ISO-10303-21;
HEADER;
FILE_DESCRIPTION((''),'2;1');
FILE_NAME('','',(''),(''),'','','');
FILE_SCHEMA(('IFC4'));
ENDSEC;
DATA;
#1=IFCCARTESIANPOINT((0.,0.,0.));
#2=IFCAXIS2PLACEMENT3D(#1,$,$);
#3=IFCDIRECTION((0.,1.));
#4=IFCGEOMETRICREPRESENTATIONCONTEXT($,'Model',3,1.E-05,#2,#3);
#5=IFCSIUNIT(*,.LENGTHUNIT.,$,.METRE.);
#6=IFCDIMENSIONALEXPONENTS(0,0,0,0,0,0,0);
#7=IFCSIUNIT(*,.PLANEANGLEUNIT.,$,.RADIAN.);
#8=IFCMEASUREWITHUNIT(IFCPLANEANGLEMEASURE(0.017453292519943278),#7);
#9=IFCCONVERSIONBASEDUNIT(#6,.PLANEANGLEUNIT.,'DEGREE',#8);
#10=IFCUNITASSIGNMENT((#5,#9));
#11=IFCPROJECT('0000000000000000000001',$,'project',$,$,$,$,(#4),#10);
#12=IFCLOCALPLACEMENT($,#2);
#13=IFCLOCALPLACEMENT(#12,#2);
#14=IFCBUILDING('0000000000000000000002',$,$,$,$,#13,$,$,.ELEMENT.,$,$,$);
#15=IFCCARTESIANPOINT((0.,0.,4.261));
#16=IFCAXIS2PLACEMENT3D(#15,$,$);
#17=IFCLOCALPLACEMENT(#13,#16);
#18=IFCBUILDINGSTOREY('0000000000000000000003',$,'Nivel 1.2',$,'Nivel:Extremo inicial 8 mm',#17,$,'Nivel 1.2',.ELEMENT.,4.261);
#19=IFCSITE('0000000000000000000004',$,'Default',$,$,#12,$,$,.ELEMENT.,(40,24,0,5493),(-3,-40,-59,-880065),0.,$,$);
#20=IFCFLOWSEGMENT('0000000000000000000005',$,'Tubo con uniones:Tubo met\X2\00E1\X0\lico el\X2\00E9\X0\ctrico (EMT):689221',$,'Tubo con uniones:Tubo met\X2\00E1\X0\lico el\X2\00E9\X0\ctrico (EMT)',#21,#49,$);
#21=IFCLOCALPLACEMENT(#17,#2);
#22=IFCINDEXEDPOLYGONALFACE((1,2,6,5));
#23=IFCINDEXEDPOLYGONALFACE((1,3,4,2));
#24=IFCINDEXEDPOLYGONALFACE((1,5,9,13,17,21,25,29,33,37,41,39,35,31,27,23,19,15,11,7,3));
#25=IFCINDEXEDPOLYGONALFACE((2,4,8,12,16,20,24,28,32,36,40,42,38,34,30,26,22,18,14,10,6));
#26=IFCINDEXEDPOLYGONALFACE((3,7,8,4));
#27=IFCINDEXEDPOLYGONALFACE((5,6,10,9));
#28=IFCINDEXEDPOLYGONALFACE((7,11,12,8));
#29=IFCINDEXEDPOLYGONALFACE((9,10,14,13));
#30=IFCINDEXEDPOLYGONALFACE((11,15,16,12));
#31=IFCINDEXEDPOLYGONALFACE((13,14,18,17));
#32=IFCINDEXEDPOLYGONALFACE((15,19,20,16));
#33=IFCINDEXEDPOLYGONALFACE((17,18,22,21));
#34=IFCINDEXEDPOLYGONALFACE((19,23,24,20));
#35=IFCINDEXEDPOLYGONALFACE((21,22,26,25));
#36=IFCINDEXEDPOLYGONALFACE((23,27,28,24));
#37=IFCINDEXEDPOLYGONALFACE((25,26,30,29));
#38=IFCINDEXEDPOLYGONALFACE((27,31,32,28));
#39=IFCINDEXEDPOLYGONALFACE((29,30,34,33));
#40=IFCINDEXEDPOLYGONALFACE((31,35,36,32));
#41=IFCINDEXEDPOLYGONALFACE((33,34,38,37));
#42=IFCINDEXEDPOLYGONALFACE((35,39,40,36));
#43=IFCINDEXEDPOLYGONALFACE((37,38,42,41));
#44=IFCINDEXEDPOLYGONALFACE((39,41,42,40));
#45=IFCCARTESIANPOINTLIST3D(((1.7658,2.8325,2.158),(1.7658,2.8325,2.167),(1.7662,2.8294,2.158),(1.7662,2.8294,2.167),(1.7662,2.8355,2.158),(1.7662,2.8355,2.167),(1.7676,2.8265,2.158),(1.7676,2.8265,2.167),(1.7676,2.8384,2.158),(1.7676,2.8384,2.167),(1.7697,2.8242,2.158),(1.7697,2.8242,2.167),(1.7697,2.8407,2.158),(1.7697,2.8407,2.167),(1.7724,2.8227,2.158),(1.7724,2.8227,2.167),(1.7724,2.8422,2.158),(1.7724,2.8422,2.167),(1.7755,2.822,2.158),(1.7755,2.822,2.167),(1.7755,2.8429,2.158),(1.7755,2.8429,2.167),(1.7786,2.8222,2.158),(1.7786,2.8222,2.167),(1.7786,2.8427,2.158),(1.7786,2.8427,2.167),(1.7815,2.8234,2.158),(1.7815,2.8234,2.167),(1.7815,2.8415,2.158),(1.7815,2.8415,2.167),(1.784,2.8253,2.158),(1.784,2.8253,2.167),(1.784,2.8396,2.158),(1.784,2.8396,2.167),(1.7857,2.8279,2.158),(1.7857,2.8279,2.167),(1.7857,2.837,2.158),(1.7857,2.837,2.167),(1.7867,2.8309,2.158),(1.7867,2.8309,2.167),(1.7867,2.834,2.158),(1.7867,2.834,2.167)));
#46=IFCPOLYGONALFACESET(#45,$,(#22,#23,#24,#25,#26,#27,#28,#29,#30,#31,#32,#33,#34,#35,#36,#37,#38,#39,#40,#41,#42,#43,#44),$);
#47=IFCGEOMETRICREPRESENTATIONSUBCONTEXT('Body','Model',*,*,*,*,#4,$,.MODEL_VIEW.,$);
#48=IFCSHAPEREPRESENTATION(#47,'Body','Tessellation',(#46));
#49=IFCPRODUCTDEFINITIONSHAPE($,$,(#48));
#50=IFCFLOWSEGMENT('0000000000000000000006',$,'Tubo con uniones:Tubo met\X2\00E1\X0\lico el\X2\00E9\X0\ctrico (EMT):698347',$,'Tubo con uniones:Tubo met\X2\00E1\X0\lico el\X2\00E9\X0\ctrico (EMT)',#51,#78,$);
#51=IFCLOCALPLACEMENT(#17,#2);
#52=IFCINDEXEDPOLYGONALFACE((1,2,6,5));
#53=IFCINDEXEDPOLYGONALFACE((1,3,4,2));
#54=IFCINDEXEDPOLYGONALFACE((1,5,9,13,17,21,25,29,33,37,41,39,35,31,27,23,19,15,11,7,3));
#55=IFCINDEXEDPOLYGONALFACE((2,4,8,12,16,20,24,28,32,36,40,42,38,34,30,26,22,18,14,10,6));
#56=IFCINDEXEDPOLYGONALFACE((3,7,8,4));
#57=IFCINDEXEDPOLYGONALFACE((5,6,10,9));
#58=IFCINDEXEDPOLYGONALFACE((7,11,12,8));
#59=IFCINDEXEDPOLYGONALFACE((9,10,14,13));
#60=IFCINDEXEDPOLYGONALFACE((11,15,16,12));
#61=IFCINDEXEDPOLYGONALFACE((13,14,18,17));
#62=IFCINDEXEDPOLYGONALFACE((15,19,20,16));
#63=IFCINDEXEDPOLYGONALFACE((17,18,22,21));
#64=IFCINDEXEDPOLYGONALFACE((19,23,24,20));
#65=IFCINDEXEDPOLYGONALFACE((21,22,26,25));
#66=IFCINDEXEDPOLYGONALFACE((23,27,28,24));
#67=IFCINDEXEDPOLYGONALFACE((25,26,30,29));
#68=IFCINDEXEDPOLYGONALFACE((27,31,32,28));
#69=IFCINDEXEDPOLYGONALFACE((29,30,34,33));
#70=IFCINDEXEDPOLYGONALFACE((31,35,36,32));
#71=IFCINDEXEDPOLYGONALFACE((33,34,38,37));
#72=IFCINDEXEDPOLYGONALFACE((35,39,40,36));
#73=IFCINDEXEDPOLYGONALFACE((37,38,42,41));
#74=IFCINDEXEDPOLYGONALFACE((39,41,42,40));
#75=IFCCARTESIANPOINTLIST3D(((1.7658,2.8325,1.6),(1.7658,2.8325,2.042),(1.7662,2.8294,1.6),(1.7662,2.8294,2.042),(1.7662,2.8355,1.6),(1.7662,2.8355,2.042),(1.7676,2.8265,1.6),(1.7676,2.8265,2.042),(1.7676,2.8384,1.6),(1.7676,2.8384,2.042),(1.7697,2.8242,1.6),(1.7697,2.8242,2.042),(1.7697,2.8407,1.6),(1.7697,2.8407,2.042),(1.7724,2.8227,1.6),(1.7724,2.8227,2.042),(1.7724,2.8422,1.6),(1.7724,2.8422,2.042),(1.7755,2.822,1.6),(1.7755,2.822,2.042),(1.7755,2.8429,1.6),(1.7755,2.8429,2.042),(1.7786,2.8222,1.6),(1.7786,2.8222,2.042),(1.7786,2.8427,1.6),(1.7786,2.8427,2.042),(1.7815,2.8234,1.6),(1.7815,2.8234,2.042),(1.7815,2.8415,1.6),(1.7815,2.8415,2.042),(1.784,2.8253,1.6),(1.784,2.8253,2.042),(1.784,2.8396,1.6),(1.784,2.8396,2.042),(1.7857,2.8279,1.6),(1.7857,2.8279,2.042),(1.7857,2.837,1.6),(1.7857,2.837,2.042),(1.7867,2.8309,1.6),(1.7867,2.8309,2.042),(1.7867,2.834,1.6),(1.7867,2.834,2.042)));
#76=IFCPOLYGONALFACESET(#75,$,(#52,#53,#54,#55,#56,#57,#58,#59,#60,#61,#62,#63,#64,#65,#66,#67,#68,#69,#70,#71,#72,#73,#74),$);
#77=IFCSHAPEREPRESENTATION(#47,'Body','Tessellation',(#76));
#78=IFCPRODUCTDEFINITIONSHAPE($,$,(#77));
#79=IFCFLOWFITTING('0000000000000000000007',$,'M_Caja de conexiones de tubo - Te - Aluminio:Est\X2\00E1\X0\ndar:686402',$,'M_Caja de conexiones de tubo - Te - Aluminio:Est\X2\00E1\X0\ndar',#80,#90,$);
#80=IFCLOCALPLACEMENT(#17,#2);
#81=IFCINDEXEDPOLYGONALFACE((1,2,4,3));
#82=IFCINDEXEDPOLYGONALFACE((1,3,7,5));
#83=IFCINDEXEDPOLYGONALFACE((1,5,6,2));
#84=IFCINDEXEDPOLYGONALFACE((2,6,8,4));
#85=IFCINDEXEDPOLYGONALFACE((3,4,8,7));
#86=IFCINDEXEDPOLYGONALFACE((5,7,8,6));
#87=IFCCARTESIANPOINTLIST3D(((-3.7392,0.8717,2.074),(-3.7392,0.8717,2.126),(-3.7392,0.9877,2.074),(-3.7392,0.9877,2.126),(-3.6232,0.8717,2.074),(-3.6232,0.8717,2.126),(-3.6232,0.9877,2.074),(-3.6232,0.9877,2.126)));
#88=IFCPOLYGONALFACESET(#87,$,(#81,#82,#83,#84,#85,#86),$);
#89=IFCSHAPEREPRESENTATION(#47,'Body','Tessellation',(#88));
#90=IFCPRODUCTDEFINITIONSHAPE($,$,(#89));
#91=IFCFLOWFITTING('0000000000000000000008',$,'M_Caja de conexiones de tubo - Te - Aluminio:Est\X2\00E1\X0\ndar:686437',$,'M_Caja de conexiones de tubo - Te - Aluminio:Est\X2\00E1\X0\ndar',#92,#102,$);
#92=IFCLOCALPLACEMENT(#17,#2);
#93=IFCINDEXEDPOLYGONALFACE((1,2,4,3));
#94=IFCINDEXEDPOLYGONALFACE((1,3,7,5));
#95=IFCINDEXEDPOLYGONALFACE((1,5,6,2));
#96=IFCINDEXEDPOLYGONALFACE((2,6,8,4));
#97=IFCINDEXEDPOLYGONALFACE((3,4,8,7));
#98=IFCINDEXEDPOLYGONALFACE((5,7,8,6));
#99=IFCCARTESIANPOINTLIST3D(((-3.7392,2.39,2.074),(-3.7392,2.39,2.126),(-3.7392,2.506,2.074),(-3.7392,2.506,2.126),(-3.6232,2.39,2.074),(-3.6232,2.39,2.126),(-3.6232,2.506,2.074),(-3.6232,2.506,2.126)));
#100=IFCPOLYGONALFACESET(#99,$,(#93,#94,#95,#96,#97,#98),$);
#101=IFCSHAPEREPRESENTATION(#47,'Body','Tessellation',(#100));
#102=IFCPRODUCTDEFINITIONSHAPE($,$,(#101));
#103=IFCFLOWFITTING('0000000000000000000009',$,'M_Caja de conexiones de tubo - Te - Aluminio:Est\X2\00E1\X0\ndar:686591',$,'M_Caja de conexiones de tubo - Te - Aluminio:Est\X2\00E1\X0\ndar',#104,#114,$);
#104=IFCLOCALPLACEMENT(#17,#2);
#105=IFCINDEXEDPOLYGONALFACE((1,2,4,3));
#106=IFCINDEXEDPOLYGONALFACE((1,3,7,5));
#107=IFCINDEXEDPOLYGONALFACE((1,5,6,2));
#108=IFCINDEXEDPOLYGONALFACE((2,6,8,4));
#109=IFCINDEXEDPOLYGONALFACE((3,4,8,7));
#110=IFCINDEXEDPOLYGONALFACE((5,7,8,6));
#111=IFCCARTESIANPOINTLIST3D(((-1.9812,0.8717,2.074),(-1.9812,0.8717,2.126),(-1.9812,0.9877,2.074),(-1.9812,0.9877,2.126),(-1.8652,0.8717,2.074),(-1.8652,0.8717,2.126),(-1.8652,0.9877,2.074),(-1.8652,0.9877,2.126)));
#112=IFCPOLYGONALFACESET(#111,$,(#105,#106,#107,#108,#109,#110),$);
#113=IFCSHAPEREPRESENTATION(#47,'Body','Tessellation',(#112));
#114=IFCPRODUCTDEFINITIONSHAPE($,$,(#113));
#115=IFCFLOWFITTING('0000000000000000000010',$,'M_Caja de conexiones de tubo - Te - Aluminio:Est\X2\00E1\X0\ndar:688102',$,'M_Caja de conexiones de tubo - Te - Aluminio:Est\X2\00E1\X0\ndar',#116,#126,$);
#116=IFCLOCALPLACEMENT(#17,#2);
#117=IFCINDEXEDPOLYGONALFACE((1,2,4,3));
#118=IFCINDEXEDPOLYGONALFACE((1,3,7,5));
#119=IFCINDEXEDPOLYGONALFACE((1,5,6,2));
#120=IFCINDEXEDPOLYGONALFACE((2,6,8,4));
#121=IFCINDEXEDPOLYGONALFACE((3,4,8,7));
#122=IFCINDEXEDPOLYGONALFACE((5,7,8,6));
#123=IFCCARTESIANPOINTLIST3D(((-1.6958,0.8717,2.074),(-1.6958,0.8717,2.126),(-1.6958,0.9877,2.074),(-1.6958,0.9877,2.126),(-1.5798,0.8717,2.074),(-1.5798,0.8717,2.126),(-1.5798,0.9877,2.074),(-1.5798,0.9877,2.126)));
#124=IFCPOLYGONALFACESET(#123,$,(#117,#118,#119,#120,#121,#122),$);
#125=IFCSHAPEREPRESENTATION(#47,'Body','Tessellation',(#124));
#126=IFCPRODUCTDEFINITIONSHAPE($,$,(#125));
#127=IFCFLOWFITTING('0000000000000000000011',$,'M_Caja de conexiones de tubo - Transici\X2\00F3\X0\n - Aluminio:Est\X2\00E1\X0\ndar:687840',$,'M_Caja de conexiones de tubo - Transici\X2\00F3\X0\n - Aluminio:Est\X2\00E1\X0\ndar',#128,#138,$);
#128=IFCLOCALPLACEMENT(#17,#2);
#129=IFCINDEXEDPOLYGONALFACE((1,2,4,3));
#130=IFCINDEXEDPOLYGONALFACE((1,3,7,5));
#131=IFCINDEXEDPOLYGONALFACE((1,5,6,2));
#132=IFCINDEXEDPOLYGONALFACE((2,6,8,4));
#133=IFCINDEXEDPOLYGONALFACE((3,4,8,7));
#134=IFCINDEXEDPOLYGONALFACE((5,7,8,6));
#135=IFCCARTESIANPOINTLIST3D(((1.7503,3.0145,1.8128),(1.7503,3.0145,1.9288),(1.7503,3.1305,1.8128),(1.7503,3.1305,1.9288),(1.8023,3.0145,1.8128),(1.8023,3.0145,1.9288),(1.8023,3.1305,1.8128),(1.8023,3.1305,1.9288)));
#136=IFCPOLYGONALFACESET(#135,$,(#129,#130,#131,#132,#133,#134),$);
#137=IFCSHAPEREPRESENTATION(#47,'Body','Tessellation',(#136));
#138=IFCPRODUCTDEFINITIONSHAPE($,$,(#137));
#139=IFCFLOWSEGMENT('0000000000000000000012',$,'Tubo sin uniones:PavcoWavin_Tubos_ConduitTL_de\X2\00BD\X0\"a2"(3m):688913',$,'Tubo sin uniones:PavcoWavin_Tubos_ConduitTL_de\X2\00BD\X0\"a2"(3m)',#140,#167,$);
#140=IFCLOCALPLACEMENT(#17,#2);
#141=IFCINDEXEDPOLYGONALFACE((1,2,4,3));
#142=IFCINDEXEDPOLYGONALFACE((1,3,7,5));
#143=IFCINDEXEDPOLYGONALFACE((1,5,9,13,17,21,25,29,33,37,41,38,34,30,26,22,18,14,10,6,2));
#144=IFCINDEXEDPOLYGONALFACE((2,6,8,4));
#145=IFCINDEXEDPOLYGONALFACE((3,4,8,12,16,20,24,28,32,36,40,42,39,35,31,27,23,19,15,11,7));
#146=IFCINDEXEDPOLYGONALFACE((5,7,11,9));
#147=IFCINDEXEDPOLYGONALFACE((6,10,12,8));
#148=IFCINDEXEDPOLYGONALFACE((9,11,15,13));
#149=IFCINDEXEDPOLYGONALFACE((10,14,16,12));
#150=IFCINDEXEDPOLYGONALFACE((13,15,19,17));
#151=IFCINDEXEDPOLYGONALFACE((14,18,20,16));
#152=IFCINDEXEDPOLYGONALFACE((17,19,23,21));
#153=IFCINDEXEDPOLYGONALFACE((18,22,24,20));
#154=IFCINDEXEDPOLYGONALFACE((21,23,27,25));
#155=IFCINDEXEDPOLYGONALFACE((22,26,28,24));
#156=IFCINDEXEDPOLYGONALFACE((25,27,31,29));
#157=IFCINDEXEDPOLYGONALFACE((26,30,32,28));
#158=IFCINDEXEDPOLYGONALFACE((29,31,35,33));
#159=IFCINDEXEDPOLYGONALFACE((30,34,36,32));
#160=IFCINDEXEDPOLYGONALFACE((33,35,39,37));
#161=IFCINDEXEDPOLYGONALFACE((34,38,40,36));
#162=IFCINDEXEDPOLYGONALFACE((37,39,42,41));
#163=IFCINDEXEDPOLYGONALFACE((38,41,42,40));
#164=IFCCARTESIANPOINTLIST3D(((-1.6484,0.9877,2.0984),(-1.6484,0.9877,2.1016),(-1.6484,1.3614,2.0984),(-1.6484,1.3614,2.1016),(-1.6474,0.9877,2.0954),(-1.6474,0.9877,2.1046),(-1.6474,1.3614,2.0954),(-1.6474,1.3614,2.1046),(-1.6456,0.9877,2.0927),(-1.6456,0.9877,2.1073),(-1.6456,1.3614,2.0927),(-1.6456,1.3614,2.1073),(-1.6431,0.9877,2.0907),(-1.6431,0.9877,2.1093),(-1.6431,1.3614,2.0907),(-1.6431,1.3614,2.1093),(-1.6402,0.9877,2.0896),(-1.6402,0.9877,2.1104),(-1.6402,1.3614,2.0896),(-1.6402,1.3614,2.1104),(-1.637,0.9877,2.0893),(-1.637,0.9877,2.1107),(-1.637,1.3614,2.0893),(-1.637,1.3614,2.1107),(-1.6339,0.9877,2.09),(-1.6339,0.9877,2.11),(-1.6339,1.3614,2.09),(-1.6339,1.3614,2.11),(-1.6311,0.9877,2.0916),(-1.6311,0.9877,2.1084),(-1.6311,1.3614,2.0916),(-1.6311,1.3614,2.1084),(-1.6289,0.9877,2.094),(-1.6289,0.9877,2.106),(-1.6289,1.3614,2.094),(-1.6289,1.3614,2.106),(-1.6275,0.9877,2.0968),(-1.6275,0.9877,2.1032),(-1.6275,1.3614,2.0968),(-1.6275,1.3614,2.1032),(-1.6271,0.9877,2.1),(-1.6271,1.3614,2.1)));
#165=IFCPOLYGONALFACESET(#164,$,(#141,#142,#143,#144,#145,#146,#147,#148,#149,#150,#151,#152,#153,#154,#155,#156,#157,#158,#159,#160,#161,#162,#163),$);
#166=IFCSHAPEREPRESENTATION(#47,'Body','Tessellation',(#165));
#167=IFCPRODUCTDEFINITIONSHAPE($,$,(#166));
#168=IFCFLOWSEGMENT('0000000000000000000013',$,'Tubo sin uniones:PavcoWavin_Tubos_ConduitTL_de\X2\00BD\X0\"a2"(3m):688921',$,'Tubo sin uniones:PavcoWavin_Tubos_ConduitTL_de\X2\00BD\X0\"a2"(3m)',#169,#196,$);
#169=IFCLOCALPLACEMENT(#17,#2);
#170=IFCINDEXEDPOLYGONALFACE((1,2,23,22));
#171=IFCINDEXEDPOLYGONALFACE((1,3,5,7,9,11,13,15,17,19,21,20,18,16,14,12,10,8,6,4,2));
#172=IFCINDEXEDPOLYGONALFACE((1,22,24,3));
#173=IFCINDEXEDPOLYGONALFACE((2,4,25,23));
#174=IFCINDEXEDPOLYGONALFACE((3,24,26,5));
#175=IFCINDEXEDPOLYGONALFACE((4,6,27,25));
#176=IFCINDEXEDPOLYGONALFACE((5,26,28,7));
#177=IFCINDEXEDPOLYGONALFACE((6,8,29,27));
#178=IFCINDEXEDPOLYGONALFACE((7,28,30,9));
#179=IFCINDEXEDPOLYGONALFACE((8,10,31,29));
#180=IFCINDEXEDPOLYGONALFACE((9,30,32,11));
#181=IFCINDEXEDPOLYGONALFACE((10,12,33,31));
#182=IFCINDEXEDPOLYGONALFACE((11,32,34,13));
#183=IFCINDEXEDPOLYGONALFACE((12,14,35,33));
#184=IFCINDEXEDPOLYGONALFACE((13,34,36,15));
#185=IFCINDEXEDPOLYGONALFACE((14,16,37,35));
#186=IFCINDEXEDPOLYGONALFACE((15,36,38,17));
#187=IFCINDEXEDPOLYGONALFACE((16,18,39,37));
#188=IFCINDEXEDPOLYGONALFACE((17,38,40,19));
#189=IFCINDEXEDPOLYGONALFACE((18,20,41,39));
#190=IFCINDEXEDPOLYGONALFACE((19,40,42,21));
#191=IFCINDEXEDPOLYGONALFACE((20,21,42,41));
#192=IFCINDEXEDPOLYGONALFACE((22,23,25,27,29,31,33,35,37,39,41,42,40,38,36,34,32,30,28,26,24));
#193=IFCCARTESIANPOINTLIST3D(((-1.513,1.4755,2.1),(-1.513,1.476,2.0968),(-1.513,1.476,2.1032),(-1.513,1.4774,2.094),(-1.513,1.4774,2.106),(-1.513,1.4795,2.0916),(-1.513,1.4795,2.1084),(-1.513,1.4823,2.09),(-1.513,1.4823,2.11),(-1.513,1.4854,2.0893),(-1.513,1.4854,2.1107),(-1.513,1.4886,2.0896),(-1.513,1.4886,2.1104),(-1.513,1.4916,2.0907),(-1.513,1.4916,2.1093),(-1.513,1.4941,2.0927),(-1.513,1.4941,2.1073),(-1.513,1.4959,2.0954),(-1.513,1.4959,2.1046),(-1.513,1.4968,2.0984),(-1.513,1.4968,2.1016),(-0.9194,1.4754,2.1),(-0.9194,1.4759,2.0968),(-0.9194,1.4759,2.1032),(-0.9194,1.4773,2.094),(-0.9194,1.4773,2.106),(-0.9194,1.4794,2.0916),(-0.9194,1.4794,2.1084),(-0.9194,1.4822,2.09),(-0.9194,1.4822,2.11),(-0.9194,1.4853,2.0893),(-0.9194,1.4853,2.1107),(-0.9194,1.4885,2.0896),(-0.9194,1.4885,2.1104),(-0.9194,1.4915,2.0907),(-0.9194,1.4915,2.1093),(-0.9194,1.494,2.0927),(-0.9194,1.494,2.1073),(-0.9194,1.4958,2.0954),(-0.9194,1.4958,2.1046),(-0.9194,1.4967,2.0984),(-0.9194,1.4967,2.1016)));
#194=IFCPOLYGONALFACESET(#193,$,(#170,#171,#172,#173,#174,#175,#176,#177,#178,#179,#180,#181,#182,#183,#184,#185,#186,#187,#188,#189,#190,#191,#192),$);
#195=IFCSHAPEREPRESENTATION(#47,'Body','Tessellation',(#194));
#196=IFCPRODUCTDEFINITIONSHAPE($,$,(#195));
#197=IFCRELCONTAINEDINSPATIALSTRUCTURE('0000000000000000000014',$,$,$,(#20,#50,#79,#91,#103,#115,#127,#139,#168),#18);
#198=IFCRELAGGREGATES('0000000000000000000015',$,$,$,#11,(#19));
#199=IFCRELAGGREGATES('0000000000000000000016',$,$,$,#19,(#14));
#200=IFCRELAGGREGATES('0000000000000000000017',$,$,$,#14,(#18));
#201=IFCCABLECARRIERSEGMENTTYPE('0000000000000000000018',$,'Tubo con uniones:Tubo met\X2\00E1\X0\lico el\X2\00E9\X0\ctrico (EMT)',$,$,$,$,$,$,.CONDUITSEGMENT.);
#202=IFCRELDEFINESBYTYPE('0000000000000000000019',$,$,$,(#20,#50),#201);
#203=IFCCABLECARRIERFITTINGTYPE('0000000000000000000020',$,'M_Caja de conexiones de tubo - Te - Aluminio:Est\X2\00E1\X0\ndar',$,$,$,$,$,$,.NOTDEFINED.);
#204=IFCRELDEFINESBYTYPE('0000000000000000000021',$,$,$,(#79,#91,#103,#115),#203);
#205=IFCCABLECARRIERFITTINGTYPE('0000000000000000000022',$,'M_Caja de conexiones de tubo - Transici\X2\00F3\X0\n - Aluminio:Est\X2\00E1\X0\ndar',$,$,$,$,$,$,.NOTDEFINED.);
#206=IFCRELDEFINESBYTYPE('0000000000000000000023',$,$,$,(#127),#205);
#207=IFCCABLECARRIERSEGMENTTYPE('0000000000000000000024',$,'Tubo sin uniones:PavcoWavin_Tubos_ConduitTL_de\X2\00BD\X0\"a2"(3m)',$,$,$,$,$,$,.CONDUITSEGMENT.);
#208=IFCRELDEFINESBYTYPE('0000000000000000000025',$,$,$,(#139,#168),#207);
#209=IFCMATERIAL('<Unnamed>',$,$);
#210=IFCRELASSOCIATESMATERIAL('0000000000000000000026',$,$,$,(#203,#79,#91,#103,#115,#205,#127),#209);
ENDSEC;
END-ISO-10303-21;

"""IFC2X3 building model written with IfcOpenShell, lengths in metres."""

from ifc_helpers import new_model, entity, si_unit, converted_unit, direction, frame, frame_2d, origin, origin_2d_with_axis, place, context, subcontext, project, spatial, rectangle, circle, extrude, source, transform, mapped, material, type_object, type_shapes, element, save


model = new_model("IFC2X3")

# Units and contexts
model_context = context("Model", 3, precision=1e-05, world=origin(), true_north=direction((0.0, 1.0)))
body_context = subcontext(model_context, "Body", "Model", "MODEL_VIEW")
ifc_project = project(units=[si_unit("LENGTHUNIT", "METRE"), converted_unit("PLANEANGLEUNIT", "DEGREE", entity("IfcPlaneAngleMeasure", 0.017453292519943278), si_unit("PLANEANGLEUNIT", "RADIAN"), dimensions=[0, 0, 0, 0, 0, 0, 0])], contexts=[model_context])

# Site, building, storey
site_placement = place(None, origin())
site = spatial("IfcSite", under=ifc_project, at=site_placement, Name="Default", CompositionType="ELEMENT", RefLatitude=(40, 24, 0, 5493), RefLongitude=(-3, -40, -59, -880065), RefElevation=0.0)
building_placement = place(site_placement, origin())
building = spatial("IfcBuilding", under=site, at=building_placement, CompositionType="ELEMENT")
storey_placement = place(building_placement, frame((0.0, 0.0, 4.261)))
storey = spatial("IfcBuildingStorey", under=building, at=storey_placement, Name="Nivel 1.2", ObjectType="Nivel:Extremo inicial 8 mm", LongName="Nivel 1.2", CompositionType="ELEMENT", Elevation=4.261)

# Flow segments
cable_carrier_segment_type_1 = type_object("IfcCableCarrierSegmentType", Name="Tubo con uniones:Tubo metálico eléctrico (EMT)", PredefinedType="CONDUITSEGMENT")
flow_segment_1_placement = place(storey_placement, origin())
element("IfcFlowSegment", 1, at=flow_segment_1_placement, inside=storey, type_object=cable_carrier_segment_type_1, Name="Tubo con uniones:Tubo metálico eléctrico (EMT):689221", ObjectType="Tubo con uniones:Tubo metálico eléctrico (EMT)", context=body_context, shape_type="SweptSolid", body=[
    extrude(circle(Radius=0.0105, at=origin_2d_with_axis()), frame((1.7763, 2.8325, 2.158), z_axis=(0.0, 0.0, 1.0), x_axis=(-1.0, 0.0, 0.0)), (0.0, 0.0, 1.0), 0.009),
])
flow_segment_2_placement = place(storey_placement, origin())
element("IfcFlowSegment", 2, at=flow_segment_2_placement, inside=storey, type_object=cable_carrier_segment_type_1, Name="Tubo con uniones:Tubo metálico eléctrico (EMT):698347", ObjectType="Tubo con uniones:Tubo metálico eléctrico (EMT)", context=body_context, shape_type="SweptSolid", body=[
    extrude(circle(Radius=0.0105, at=origin_2d_with_axis()), frame((1.7763, 2.8325, 1.6), z_axis=(0.0, 0.0, 1.0), x_axis=(-1.0, 0.0, 0.0)), (0.0, 0.0, 1.0), 0.442),
])

# Flow fittings
ifc_material_1 = material(Name="<Unnamed>")
cable_carrier_fitting_type_1 = type_object("IfcCableCarrierFittingType", Name="M_Caja de conexiones de tubo - Te - Aluminio:Estándar", PredefinedType="NOTDEFINED", material=ifc_material_1)
shared_shape_1 = source(origin(), body_context, "Body", "SweptSolid", [
    extrude(rectangle(XDim=0.116, YDim=0.116, at=frame_2d((0.0, 0.0), x_axis=(1.0, 0.0))), frame((0.0, 0.0, -0.026), z_axis=(0.0, 0.0, 1.0), x_axis=(-1.0, 0.0, 0.0)), (0.0, 0.0, 1.0), 0.052),
])
type_shapes(cable_carrier_fitting_type_1, [shared_shape_1])
for number, where, z_axis, x_axis, name in (
    (3, (-3.6812, 0.9297, 2.1), (0.0, 0.0, -1.0), (0.0, -1.0, 0.0), "M_Caja de conexiones de tubo - Te - Aluminio:Estándar:686402"),
    (4, (-3.6812, 2.448, 2.1), (0.0, 0.0, 1.0), (0.0, -1.0, 0.0), "M_Caja de conexiones de tubo - Te - Aluminio:Estándar:686437"),
    (5, (-1.9232, 0.9297, 2.1), (0.0, 0.0, 1.0), (-1.0, 0.0, 0.0), "M_Caja de conexiones de tubo - Te - Aluminio:Estándar:686591"),
    (6, (-1.6378, 0.9297, 2.1), (0.0, 0.0, 1.0), (-1.0, 0.0, 0.0), "M_Caja de conexiones de tubo - Te - Aluminio:Estándar:688102"),
):
    element("IfcFlowFitting", number, at=place(storey_placement, frame(where, z_axis=z_axis, x_axis=x_axis)), inside=storey, type_object=cable_carrier_fitting_type_1, material=ifc_material_1, Name=name, ObjectType="M_Caja de conexiones de tubo - Te - Aluminio:Estándar", context=body_context, shape_type="MappedRepresentation", body=[
        mapped(shared_shape_1, transform((0.0, 0.0, 0.0), scale=1.0)),
    ])
cable_carrier_fitting_type_2 = type_object("IfcCableCarrierFittingType", Name="M_Caja de conexiones de tubo - Transición - Aluminio:Estándar", PredefinedType="NOTDEFINED", material=ifc_material_1)
shared_shape_2 = source(origin(), body_context, "Body", "SweptSolid", [
    extrude(rectangle(XDim=0.116, YDim=0.116, at=origin_2d_with_axis()), frame((0.058, 0.0, -0.026), z_axis=(0.0, 0.0, 1.0), x_axis=(-1.0, 0.0, 0.0)), (0.0, 0.0, 1.0), 0.052),
])
type_shapes(cable_carrier_fitting_type_2, [shared_shape_2])
flow_fitting_1_placement = place(storey_placement, frame((1.7763, 3.0725, 1.8128), z_axis=(1.0, 0.0, 0.0), x_axis=(0.0, 0.0, 1.0)))
element("IfcFlowFitting", 7, at=flow_fitting_1_placement, inside=storey, type_object=cable_carrier_fitting_type_2, material=ifc_material_1, Name="M_Caja de conexiones de tubo - Transición - Aluminio:Estándar:687840", ObjectType="M_Caja de conexiones de tubo - Transición - Aluminio:Estándar", context=body_context, shape_type="MappedRepresentation", body=[
    mapped(shared_shape_2, transform((0.0, 0.0, 0.0), scale=1.0)),
])

# Flow segments
cable_carrier_segment_type_2 = type_object("IfcCableCarrierSegmentType", Name="Tubo sin uniones:PavcoWavin_Tubos_ConduitTL_de½\"a2\"(3m)", PredefinedType="CONDUITSEGMENT")
flow_segment_3_placement = place(storey_placement, origin())
element("IfcFlowSegment", 8, at=flow_segment_3_placement, inside=storey, type_object=cable_carrier_segment_type_2, Name="Tubo sin uniones:PavcoWavin_Tubos_ConduitTL_de½\"a2\"(3m):688913", ObjectType="Tubo sin uniones:PavcoWavin_Tubos_ConduitTL_de½\"a2\"(3m)", context=body_context, shape_type="SweptSolid", body=[
    extrude(circle(Radius=0.0107, at=origin_2d_with_axis()), frame((-1.6378, 0.9877, 2.1), z_axis=(0.0, 1.0, 0.0), x_axis=(1.0, 0.0, 0.0)), (0.0, 0.0, 1.0), 0.3738),
])
flow_segment_4_placement = place(storey_placement, origin())
element("IfcFlowSegment", 9, at=flow_segment_4_placement, inside=storey, type_object=cable_carrier_segment_type_2, Name="Tubo sin uniones:PavcoWavin_Tubos_ConduitTL_de½\"a2\"(3m):688921", ObjectType="Tubo sin uniones:PavcoWavin_Tubos_ConduitTL_de½\"a2\"(3m)", context=body_context, shape_type="SweptSolid", body=[
    extrude(circle(Radius=0.0107, at=origin_2d_with_axis()), frame((-1.513, 1.4862, 2.1), z_axis=(1.0, -0.000167, 0.0), x_axis=(-0.000167, -1.0, 0.0)), (0.0, 0.0, 1.0), 0.5936),
])

save(model, "model.ifc")
